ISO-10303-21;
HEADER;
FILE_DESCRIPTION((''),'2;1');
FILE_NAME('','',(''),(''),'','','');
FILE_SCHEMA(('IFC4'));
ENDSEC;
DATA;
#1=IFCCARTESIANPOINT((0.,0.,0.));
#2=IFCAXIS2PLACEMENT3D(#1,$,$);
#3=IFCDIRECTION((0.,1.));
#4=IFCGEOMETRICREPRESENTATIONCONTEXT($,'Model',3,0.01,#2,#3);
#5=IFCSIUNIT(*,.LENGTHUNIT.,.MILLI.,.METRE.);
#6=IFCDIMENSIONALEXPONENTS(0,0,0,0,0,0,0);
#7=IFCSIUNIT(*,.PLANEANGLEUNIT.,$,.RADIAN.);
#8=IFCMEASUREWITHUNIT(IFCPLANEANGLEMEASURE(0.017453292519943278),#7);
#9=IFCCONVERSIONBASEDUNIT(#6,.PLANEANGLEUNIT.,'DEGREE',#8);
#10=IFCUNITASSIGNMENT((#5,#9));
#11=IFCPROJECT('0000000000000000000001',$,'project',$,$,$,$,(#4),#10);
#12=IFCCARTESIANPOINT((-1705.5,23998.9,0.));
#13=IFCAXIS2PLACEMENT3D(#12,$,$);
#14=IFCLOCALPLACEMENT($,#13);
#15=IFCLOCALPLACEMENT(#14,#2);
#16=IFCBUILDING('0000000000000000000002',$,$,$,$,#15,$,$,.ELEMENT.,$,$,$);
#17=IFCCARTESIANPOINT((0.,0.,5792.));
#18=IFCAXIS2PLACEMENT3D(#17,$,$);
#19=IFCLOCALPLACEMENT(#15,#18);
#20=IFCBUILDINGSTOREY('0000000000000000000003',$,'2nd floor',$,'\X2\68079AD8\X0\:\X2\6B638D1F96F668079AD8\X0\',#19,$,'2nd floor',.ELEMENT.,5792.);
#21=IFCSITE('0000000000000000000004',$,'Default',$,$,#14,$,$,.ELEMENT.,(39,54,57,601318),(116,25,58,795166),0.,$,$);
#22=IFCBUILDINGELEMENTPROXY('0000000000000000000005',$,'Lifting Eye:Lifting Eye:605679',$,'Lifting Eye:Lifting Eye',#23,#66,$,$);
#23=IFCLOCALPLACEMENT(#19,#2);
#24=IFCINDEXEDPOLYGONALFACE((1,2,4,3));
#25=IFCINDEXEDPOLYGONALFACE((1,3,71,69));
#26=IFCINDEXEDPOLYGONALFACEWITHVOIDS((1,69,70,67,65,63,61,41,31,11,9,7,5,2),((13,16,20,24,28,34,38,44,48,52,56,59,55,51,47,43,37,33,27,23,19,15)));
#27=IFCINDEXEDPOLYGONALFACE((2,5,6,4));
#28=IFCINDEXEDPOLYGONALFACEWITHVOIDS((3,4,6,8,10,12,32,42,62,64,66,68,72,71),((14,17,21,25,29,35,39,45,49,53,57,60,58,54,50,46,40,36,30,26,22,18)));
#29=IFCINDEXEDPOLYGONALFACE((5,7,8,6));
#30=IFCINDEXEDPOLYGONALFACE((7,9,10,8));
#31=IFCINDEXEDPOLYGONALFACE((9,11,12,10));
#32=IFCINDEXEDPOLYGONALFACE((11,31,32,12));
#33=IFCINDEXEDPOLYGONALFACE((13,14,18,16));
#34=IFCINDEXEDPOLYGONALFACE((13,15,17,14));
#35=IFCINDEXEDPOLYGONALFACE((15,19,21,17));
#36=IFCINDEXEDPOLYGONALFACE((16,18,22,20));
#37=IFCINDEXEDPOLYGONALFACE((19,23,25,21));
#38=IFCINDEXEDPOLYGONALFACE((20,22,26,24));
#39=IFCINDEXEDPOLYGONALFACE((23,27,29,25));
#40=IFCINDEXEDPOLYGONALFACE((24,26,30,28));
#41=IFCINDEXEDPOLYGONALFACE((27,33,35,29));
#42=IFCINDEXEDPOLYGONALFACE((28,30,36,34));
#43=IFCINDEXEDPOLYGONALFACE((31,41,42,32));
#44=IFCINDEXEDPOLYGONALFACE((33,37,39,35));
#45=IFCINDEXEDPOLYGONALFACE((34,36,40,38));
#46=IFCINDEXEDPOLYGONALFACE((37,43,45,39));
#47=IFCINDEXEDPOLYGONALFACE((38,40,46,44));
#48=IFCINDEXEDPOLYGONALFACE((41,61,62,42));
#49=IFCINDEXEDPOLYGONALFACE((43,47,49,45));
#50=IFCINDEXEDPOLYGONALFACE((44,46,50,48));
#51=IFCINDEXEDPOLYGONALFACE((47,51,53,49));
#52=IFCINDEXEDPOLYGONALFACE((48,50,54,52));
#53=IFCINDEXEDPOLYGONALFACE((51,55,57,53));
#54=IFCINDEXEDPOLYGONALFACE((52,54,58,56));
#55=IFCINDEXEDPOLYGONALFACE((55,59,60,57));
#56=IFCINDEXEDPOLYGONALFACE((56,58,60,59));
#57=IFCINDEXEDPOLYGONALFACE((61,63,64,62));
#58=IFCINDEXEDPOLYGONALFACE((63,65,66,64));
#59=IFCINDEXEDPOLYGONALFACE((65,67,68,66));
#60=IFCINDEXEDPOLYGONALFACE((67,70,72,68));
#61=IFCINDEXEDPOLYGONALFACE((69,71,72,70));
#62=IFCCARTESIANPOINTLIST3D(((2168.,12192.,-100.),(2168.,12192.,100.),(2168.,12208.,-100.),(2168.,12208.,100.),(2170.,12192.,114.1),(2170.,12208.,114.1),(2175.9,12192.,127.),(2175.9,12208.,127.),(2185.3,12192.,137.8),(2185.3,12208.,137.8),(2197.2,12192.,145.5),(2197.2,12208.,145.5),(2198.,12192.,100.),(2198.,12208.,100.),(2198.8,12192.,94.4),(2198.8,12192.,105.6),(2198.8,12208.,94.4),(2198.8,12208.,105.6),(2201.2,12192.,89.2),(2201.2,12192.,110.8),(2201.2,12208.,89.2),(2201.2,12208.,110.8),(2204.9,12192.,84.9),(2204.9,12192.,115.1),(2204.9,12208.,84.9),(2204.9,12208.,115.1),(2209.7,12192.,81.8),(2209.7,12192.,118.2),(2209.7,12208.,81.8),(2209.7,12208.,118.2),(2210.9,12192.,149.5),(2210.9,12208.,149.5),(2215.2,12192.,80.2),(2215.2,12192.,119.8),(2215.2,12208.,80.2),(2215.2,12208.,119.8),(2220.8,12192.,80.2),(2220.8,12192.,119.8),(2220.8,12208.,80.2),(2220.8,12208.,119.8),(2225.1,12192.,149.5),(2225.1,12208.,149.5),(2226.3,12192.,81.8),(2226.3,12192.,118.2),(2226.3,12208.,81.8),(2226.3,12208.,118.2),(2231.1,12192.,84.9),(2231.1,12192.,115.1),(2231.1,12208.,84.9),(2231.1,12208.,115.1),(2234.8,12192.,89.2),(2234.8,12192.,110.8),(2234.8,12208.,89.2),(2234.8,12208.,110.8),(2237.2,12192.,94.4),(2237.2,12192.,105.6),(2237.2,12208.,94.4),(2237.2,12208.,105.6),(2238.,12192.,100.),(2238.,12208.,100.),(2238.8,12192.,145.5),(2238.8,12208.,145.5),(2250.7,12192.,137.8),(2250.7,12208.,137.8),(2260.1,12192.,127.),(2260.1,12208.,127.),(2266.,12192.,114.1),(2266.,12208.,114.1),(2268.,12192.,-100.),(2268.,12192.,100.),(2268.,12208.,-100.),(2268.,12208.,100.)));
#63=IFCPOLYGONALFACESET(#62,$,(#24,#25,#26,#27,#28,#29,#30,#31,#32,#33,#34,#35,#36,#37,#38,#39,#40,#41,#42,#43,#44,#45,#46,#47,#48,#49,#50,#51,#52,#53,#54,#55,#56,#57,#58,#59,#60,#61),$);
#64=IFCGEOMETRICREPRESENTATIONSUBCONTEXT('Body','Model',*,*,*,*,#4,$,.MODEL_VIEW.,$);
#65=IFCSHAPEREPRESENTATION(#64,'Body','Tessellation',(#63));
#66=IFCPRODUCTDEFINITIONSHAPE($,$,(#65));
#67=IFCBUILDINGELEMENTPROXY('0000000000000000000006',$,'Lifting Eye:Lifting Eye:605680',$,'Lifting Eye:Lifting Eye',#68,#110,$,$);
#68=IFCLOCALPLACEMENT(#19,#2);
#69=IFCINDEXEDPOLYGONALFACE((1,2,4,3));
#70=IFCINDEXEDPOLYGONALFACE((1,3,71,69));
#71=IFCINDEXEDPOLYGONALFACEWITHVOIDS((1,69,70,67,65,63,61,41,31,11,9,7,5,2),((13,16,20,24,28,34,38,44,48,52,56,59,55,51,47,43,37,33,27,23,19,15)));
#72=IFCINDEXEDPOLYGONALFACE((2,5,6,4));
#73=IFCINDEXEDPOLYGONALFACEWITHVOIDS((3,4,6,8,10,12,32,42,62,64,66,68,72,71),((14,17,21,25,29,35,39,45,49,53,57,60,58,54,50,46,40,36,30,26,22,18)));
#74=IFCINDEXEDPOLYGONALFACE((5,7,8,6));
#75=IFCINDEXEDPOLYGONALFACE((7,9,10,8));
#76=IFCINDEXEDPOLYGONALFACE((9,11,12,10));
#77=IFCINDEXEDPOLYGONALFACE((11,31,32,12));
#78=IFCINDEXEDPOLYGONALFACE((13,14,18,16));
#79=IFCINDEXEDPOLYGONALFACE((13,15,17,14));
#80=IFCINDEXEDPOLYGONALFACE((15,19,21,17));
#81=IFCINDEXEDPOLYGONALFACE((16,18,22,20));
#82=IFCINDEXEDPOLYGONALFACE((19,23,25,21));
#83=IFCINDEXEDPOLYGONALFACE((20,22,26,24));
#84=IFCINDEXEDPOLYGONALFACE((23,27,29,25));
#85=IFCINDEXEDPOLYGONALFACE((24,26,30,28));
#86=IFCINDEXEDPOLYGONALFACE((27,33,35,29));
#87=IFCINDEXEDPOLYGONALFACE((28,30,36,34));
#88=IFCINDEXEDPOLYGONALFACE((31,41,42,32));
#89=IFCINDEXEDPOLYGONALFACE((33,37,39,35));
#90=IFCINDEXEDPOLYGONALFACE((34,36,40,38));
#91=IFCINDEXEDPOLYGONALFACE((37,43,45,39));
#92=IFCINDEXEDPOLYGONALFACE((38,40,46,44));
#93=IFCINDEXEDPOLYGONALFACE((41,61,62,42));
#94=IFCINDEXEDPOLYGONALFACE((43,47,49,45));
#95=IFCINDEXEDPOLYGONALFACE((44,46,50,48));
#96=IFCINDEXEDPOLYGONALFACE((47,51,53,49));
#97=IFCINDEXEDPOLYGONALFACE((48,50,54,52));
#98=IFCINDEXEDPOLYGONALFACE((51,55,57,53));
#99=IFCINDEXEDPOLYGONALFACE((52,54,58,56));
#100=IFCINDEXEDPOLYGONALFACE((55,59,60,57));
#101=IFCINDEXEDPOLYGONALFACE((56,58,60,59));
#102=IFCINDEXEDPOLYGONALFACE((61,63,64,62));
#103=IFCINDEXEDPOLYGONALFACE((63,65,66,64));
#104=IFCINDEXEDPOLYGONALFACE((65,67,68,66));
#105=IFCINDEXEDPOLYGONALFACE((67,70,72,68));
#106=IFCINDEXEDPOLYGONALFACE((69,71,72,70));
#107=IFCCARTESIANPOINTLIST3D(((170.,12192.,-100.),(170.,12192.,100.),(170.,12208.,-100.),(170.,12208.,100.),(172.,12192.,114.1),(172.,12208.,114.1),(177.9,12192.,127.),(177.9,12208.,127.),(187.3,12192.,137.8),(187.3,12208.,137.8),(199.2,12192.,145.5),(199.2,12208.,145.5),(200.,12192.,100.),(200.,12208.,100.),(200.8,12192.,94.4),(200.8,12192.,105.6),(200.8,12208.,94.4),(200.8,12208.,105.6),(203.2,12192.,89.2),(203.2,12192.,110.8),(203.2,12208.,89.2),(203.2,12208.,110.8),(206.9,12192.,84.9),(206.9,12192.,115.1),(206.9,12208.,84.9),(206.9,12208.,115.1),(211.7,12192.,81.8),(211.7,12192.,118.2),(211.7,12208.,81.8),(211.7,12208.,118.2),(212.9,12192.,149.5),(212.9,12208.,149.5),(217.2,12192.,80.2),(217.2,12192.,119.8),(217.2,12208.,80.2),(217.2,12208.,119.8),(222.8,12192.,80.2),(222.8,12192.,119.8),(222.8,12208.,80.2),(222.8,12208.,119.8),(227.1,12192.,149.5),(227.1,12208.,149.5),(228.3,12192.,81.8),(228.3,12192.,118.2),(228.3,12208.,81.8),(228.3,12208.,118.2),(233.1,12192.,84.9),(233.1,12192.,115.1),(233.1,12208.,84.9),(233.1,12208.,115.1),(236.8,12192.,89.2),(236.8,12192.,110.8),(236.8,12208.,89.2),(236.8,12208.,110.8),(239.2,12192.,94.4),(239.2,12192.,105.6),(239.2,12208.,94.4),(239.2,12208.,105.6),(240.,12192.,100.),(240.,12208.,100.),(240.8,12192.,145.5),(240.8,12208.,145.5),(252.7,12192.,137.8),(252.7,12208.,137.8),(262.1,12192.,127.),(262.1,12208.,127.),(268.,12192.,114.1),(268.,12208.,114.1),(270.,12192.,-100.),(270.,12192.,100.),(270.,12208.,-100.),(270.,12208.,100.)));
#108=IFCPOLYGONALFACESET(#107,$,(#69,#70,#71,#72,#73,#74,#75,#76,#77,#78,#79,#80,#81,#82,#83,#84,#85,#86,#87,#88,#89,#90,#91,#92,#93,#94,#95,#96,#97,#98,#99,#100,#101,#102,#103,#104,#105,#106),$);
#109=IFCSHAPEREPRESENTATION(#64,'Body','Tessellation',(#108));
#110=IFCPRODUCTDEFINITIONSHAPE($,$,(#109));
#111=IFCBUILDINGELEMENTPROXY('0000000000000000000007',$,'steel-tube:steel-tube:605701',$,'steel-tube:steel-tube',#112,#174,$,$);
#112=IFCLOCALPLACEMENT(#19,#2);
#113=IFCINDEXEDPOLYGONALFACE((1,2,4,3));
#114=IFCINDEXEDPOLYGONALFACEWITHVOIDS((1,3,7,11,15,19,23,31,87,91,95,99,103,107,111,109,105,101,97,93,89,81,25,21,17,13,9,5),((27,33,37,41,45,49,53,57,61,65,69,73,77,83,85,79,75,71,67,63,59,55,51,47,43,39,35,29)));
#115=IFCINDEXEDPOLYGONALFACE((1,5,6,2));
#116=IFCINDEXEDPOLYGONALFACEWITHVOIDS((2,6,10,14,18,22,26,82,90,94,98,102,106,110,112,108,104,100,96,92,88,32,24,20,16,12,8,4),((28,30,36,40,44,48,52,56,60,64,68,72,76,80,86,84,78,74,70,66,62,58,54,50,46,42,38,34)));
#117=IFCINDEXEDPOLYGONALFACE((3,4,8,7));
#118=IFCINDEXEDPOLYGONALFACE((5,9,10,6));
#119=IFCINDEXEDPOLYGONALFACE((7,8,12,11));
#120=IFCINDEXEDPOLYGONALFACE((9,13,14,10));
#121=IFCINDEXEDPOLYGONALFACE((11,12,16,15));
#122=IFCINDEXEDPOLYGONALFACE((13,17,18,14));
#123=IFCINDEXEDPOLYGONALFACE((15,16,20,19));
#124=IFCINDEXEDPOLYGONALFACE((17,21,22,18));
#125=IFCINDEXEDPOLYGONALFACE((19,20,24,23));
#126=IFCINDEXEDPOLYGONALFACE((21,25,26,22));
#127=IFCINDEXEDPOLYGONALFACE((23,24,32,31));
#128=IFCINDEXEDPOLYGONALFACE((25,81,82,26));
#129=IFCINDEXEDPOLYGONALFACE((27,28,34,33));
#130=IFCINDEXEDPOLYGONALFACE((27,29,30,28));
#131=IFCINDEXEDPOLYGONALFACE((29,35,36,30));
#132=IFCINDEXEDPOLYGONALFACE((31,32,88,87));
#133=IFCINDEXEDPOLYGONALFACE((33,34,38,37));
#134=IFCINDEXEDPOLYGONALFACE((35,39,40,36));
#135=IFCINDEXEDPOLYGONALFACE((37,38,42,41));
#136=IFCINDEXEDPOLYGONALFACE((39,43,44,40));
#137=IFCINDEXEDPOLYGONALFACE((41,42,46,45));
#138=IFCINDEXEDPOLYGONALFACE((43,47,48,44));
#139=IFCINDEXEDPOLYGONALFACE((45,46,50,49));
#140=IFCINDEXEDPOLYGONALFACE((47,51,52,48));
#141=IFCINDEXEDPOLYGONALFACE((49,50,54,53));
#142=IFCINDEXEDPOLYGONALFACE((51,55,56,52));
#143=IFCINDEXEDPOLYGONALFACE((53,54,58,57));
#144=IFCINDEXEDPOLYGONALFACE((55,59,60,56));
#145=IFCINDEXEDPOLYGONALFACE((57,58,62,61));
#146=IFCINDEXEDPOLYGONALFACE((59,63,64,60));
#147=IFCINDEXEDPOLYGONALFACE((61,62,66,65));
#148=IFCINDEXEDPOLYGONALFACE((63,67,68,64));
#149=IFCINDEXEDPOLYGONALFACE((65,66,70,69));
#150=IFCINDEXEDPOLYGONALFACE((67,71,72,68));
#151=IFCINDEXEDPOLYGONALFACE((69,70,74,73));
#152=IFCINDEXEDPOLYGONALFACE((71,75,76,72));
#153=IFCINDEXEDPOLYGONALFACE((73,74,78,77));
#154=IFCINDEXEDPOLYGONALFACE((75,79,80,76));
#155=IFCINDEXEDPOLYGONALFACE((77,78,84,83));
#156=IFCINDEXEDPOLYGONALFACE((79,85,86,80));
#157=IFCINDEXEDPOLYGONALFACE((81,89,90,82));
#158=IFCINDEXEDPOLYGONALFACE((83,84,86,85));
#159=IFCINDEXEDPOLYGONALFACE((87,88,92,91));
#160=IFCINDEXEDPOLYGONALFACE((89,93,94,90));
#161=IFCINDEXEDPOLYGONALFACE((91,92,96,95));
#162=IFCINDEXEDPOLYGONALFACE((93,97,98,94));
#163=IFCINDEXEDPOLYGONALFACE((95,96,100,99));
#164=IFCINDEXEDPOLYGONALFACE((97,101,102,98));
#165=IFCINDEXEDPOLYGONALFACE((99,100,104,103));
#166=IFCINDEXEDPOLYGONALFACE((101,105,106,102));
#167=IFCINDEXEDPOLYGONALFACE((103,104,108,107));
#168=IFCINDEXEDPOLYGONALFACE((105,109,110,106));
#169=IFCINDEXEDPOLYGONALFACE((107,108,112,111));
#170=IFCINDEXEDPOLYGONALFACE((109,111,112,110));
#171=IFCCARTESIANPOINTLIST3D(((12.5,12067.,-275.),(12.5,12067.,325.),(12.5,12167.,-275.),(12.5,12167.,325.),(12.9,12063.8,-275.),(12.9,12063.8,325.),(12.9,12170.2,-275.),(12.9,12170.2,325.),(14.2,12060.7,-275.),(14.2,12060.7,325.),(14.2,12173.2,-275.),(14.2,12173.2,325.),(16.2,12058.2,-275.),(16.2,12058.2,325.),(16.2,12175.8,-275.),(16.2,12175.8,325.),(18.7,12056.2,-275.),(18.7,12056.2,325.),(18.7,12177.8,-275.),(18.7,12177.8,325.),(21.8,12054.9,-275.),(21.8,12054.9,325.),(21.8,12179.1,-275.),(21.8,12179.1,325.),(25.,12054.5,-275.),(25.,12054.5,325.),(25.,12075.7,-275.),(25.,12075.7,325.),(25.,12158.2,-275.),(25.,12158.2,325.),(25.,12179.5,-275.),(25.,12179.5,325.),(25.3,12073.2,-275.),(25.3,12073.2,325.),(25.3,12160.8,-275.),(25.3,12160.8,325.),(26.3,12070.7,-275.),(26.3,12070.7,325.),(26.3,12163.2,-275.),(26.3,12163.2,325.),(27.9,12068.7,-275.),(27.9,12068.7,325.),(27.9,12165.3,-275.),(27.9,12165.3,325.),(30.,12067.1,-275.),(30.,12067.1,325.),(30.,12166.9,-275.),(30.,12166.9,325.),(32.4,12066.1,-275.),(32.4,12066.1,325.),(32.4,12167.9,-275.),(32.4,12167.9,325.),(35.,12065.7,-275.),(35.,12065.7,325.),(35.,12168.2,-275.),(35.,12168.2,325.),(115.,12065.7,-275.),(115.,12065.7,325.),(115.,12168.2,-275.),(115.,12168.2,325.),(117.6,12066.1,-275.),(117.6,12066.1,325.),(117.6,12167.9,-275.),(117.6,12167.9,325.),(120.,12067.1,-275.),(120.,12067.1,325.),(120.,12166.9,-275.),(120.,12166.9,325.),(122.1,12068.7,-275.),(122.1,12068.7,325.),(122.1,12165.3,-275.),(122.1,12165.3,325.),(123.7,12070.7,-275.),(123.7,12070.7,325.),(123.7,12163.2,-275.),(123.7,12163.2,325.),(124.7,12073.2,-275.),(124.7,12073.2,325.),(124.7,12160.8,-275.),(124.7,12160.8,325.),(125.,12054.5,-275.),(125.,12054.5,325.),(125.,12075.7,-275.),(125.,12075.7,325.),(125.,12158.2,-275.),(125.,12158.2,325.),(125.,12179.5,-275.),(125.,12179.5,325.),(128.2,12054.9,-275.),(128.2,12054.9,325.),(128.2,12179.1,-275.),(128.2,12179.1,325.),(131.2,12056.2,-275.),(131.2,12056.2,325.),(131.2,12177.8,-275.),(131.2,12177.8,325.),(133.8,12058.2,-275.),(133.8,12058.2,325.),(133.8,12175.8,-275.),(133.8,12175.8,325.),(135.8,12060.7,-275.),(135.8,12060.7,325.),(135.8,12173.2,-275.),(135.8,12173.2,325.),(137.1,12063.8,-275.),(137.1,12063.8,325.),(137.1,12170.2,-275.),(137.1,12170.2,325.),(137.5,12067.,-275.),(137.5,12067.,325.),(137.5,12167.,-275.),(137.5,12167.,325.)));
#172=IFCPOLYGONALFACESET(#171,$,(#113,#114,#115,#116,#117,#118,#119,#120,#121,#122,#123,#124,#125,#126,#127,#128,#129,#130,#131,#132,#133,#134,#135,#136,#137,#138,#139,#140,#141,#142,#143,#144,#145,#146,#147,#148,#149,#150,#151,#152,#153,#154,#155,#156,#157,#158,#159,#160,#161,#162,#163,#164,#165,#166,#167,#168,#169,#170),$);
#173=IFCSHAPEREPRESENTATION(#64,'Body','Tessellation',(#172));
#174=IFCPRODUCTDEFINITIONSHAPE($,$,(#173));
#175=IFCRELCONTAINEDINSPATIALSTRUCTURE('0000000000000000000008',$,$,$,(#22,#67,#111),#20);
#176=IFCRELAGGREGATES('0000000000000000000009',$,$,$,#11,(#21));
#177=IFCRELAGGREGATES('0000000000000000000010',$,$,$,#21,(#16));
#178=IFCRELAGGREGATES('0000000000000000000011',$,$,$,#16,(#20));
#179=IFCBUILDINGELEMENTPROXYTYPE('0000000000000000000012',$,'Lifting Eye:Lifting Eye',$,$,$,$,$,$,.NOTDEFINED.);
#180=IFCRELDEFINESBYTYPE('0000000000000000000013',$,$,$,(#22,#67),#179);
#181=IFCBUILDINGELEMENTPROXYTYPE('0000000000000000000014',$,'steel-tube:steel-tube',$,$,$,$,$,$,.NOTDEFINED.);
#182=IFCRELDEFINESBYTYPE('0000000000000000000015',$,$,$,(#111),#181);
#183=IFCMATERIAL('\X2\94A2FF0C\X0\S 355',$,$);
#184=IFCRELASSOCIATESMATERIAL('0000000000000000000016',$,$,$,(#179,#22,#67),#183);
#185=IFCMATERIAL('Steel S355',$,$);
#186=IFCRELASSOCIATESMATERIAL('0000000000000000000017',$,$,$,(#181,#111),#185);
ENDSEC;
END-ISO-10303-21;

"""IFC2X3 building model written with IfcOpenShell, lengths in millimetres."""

from ifc_helpers import new_model, entity, si_unit, converted_unit, direction, frame, frame_2d, origin, place, context, subcontext, project, spatial, polyline, circle_curve, parameter, trimmed, segment, composite_curve, outline, extrude, source, transform, mapped, material, type_object, type_shapes, element, save


model = new_model("IFC2X3")

# Units and contexts
model_context = context("Model", 3, precision=0.01, world=origin(), true_north=direction((0.0, 1.0)))
body_context = subcontext(model_context, "Body", "Model", "MODEL_VIEW")
ifc_project = project(units=[si_unit("LENGTHUNIT", "METRE", prefix="MILLI"), converted_unit("PLANEANGLEUNIT", "DEGREE", entity("IfcPlaneAngleMeasure", 0.017453292519943278), si_unit("PLANEANGLEUNIT", "RADIAN"), dimensions=[0, 0, 0, 0, 0, 0, 0])], contexts=[model_context])

# Site, building, storey
site_placement = place(None, frame((-1705.5, 23998.9, 0.0)))
site = spatial("IfcSite", under=ifc_project, at=site_placement, Name="Default", CompositionType="ELEMENT", RefLatitude=(39, 54, 57, 601318), RefLongitude=(116, 25, 58, 795166), RefElevation=0.0)
building_placement = place(site_placement, origin())
building = spatial("IfcBuilding", under=site, at=building_placement, CompositionType="ELEMENT")
storey_placement = place(building_placement, frame((0.0, 0.0, 5792.0)))
storey = spatial("IfcBuildingStorey", under=building, at=storey_placement, Name="2nd floor", ObjectType="标高:正负零标高", LongName="2nd floor", CompositionType="ELEMENT", Elevation=5792.0)

# Shared definitions
ifc_material_1 = material(Name="Steel S355")

# Building element proxies
ifc_material_2 = material(Name="钢，S 355")
building_element_proxy_type_1 = type_object("IfcBuildingElementProxyType", Name="Lifting Eye:Lifting Eye", PredefinedType="NOTDEFINED", material=ifc_material_2)
shared_shape_1 = source(origin(), body_context, "Body", "SweptSolid", [
    extrude(outline(composite_curve([segment(polyline([(-100.0, -50.0), (100.0, -50.0)]), True, "CONTINUOUS"), segment(polyline([(100.0, -50.0), (100.0, 50.0)]), True, "CONTINUOUS"), segment(polyline([(100.0, 50.0), (-100.0, 50.0)]), True, "CONTINUOUS"), segment(trimmed(circle_curve(frame_2d((-100.0, 0.0), x_axis=(0.0, -1.0)), 50.0), [parameter(180.0)], [parameter(0.0)], True, "PARAMETER"), True, "CONTINUOUS")], self_intersect=False), holes=[composite_curve([segment(trimmed(circle_curve(frame_2d((-100.0, 0.0), x_axis=(0.0, -1.0)), 20.0), [parameter(180.0)], [parameter(360.0)], True, "PARAMETER"), False, "CONTINUOUS"), segment(trimmed(circle_curve(frame_2d((-100.0, 0.0), x_axis=(0.0, -1.0)), 20.0), [parameter(0.0)], [parameter(180.0)], True, "PARAMETER"), False, "CONTINUOUS")], self_intersect=False)]), frame((0.0, 17.0, -17.0), z_axis=(0.0, 1.0, 0.0), x_axis=(0.0, 0.0, -1.0)), (0.0, 0.0, 1.0), 16.0),
])
type_shapes(building_element_proxy_type_1, [shared_shape_1])
for number, where, name in (
    (1, (2218.0, 12175.0, 17.0), "Lifting Eye:Lifting Eye:605679"),
    (2, (220.0, 12175.0, 17.0), "Lifting Eye:Lifting Eye:605680"),
):
    element("IfcBuildingElementProxy", number, at=place(storey_placement, frame(where)), inside=storey, type_object=building_element_proxy_type_1, material=ifc_material_2, Name=name, ObjectType="Lifting Eye:Lifting Eye", context=body_context, shape_type="MappedRepresentation", body=[
        mapped(shared_shape_1, transform((0.0, 0.0, 0.0), scale=1.0)),
    ])
building_element_proxy_type_2 = type_object("IfcBuildingElementProxyType", Name="steel-tube:steel-tube", PredefinedType="NOTDEFINED", material=ifc_material_1)
shared_shape_2 = source(origin(), body_context, "Body", "SweptSolid", [
    extrude(outline(composite_curve([segment(trimmed(circle_curve(frame_2d((50.0, -50.0), x_axis=(1.0, 0.0)), 12.5), [parameter(270.0)], [parameter(0.0)], True, "PARAMETER"), True, "CONTINUOUS"), segment(polyline([(62.5, -50.0), (62.5, 50.0)]), True, "CONTINUOUS"), segment(trimmed(circle_curve(frame_2d((50.0, 50.0), x_axis=(1.0, 0.0)), 12.5), [parameter(0.0)], [parameter(90.0)], True, "PARAMETER"), True, "CONTINUOUS"), segment(polyline([(50.0, 62.5), (-50.0, 62.5)]), True, "CONTINUOUS"), segment(trimmed(circle_curve(frame_2d((-50.0, 50.0), x_axis=(1.0, 0.0)), 12.5), [parameter(90.0)], [parameter(180.0)], True, "PARAMETER"), True, "CONTINUOUS"), segment(polyline([(-62.5, 50.0), (-62.5, -50.0)]), True, "CONTINUOUS"), segment(trimmed(circle_curve(frame_2d((-50.0, -50.0), x_axis=(1.0, 0.0)), 12.5), [parameter(180.0)], [parameter(270.0)], True, "PARAMETER"), True, "CONTINUOUS"), segment(polyline([(-50.0, -62.5), (50.0, -62.5)]), True, "CONTINUOUS")], self_intersect=False), holes=[composite_curve([segment(trimmed(circle_curve(frame_2d((-41.2, 40.0), x_axis=(1.0, 0.0)), 10.0), [parameter(90.0)], [parameter(180.0)], True, "PARAMETER"), False, "CONTINUOUS"), segment(polyline([(-41.3, 50.0), (41.2, 50.0)]), True, "CONTINUOUS"), segment(trimmed(circle_curve(frame_2d((41.2, 40.0), x_axis=(1.0, 0.0)), 10.0), [parameter(0.0)], [parameter(90.0)], True, "PARAMETER"), False, "CONTINUOUS"), segment(polyline([(51.2, 40.0), (51.2, -40.0)]), True, "CONTINUOUS"), segment(trimmed(circle_curve(frame_2d((41.2, -40.0), x_axis=(1.0, 0.0)), 10.0), [parameter(270.0)], [parameter(360.0)], True, "PARAMETER"), False, "CONTINUOUS"), segment(polyline([(41.2, -50.0), (-41.3, -50.0)]), True, "CONTINUOUS"), segment(trimmed(circle_curve(frame_2d((-41.3, -40.0), x_axis=(1.0, 0.0)), 10.0), [parameter(180.0)], [parameter(270.0)], True, "PARAMETER"), False, "CONTINUOUS"), segment(polyline([(-51.3, -40.0), (-51.3, 40.0)]), True, "CONTINUOUS")], self_intersect=False)]), frame((62.5, 62.5, -175.0)), (0.0, 0.0, 1.0), 600.0),
])
type_shapes(building_element_proxy_type_2, [shared_shape_2])
for number, where, z_axis, x_axis, name in (
    (3, (12.5, 12179.5, -100.0), (0.0, 0.0, 1.0), (0.0, -1.0, 0.0), "steel-tube:steel-tube:605701"),
):
    element("IfcBuildingElementProxy", number, at=place(storey_placement, frame(where, z_axis=z_axis, x_axis=x_axis)), inside=storey, type_object=building_element_proxy_type_2, material=ifc_material_1, Name=name, ObjectType="steel-tube:steel-tube", context=body_context, shape_type="MappedRepresentation", body=[
        mapped(shared_shape_2, transform((0.0, 0.0, 0.0), scale=1.0)),
    ])

save(model, "model.ifc")
